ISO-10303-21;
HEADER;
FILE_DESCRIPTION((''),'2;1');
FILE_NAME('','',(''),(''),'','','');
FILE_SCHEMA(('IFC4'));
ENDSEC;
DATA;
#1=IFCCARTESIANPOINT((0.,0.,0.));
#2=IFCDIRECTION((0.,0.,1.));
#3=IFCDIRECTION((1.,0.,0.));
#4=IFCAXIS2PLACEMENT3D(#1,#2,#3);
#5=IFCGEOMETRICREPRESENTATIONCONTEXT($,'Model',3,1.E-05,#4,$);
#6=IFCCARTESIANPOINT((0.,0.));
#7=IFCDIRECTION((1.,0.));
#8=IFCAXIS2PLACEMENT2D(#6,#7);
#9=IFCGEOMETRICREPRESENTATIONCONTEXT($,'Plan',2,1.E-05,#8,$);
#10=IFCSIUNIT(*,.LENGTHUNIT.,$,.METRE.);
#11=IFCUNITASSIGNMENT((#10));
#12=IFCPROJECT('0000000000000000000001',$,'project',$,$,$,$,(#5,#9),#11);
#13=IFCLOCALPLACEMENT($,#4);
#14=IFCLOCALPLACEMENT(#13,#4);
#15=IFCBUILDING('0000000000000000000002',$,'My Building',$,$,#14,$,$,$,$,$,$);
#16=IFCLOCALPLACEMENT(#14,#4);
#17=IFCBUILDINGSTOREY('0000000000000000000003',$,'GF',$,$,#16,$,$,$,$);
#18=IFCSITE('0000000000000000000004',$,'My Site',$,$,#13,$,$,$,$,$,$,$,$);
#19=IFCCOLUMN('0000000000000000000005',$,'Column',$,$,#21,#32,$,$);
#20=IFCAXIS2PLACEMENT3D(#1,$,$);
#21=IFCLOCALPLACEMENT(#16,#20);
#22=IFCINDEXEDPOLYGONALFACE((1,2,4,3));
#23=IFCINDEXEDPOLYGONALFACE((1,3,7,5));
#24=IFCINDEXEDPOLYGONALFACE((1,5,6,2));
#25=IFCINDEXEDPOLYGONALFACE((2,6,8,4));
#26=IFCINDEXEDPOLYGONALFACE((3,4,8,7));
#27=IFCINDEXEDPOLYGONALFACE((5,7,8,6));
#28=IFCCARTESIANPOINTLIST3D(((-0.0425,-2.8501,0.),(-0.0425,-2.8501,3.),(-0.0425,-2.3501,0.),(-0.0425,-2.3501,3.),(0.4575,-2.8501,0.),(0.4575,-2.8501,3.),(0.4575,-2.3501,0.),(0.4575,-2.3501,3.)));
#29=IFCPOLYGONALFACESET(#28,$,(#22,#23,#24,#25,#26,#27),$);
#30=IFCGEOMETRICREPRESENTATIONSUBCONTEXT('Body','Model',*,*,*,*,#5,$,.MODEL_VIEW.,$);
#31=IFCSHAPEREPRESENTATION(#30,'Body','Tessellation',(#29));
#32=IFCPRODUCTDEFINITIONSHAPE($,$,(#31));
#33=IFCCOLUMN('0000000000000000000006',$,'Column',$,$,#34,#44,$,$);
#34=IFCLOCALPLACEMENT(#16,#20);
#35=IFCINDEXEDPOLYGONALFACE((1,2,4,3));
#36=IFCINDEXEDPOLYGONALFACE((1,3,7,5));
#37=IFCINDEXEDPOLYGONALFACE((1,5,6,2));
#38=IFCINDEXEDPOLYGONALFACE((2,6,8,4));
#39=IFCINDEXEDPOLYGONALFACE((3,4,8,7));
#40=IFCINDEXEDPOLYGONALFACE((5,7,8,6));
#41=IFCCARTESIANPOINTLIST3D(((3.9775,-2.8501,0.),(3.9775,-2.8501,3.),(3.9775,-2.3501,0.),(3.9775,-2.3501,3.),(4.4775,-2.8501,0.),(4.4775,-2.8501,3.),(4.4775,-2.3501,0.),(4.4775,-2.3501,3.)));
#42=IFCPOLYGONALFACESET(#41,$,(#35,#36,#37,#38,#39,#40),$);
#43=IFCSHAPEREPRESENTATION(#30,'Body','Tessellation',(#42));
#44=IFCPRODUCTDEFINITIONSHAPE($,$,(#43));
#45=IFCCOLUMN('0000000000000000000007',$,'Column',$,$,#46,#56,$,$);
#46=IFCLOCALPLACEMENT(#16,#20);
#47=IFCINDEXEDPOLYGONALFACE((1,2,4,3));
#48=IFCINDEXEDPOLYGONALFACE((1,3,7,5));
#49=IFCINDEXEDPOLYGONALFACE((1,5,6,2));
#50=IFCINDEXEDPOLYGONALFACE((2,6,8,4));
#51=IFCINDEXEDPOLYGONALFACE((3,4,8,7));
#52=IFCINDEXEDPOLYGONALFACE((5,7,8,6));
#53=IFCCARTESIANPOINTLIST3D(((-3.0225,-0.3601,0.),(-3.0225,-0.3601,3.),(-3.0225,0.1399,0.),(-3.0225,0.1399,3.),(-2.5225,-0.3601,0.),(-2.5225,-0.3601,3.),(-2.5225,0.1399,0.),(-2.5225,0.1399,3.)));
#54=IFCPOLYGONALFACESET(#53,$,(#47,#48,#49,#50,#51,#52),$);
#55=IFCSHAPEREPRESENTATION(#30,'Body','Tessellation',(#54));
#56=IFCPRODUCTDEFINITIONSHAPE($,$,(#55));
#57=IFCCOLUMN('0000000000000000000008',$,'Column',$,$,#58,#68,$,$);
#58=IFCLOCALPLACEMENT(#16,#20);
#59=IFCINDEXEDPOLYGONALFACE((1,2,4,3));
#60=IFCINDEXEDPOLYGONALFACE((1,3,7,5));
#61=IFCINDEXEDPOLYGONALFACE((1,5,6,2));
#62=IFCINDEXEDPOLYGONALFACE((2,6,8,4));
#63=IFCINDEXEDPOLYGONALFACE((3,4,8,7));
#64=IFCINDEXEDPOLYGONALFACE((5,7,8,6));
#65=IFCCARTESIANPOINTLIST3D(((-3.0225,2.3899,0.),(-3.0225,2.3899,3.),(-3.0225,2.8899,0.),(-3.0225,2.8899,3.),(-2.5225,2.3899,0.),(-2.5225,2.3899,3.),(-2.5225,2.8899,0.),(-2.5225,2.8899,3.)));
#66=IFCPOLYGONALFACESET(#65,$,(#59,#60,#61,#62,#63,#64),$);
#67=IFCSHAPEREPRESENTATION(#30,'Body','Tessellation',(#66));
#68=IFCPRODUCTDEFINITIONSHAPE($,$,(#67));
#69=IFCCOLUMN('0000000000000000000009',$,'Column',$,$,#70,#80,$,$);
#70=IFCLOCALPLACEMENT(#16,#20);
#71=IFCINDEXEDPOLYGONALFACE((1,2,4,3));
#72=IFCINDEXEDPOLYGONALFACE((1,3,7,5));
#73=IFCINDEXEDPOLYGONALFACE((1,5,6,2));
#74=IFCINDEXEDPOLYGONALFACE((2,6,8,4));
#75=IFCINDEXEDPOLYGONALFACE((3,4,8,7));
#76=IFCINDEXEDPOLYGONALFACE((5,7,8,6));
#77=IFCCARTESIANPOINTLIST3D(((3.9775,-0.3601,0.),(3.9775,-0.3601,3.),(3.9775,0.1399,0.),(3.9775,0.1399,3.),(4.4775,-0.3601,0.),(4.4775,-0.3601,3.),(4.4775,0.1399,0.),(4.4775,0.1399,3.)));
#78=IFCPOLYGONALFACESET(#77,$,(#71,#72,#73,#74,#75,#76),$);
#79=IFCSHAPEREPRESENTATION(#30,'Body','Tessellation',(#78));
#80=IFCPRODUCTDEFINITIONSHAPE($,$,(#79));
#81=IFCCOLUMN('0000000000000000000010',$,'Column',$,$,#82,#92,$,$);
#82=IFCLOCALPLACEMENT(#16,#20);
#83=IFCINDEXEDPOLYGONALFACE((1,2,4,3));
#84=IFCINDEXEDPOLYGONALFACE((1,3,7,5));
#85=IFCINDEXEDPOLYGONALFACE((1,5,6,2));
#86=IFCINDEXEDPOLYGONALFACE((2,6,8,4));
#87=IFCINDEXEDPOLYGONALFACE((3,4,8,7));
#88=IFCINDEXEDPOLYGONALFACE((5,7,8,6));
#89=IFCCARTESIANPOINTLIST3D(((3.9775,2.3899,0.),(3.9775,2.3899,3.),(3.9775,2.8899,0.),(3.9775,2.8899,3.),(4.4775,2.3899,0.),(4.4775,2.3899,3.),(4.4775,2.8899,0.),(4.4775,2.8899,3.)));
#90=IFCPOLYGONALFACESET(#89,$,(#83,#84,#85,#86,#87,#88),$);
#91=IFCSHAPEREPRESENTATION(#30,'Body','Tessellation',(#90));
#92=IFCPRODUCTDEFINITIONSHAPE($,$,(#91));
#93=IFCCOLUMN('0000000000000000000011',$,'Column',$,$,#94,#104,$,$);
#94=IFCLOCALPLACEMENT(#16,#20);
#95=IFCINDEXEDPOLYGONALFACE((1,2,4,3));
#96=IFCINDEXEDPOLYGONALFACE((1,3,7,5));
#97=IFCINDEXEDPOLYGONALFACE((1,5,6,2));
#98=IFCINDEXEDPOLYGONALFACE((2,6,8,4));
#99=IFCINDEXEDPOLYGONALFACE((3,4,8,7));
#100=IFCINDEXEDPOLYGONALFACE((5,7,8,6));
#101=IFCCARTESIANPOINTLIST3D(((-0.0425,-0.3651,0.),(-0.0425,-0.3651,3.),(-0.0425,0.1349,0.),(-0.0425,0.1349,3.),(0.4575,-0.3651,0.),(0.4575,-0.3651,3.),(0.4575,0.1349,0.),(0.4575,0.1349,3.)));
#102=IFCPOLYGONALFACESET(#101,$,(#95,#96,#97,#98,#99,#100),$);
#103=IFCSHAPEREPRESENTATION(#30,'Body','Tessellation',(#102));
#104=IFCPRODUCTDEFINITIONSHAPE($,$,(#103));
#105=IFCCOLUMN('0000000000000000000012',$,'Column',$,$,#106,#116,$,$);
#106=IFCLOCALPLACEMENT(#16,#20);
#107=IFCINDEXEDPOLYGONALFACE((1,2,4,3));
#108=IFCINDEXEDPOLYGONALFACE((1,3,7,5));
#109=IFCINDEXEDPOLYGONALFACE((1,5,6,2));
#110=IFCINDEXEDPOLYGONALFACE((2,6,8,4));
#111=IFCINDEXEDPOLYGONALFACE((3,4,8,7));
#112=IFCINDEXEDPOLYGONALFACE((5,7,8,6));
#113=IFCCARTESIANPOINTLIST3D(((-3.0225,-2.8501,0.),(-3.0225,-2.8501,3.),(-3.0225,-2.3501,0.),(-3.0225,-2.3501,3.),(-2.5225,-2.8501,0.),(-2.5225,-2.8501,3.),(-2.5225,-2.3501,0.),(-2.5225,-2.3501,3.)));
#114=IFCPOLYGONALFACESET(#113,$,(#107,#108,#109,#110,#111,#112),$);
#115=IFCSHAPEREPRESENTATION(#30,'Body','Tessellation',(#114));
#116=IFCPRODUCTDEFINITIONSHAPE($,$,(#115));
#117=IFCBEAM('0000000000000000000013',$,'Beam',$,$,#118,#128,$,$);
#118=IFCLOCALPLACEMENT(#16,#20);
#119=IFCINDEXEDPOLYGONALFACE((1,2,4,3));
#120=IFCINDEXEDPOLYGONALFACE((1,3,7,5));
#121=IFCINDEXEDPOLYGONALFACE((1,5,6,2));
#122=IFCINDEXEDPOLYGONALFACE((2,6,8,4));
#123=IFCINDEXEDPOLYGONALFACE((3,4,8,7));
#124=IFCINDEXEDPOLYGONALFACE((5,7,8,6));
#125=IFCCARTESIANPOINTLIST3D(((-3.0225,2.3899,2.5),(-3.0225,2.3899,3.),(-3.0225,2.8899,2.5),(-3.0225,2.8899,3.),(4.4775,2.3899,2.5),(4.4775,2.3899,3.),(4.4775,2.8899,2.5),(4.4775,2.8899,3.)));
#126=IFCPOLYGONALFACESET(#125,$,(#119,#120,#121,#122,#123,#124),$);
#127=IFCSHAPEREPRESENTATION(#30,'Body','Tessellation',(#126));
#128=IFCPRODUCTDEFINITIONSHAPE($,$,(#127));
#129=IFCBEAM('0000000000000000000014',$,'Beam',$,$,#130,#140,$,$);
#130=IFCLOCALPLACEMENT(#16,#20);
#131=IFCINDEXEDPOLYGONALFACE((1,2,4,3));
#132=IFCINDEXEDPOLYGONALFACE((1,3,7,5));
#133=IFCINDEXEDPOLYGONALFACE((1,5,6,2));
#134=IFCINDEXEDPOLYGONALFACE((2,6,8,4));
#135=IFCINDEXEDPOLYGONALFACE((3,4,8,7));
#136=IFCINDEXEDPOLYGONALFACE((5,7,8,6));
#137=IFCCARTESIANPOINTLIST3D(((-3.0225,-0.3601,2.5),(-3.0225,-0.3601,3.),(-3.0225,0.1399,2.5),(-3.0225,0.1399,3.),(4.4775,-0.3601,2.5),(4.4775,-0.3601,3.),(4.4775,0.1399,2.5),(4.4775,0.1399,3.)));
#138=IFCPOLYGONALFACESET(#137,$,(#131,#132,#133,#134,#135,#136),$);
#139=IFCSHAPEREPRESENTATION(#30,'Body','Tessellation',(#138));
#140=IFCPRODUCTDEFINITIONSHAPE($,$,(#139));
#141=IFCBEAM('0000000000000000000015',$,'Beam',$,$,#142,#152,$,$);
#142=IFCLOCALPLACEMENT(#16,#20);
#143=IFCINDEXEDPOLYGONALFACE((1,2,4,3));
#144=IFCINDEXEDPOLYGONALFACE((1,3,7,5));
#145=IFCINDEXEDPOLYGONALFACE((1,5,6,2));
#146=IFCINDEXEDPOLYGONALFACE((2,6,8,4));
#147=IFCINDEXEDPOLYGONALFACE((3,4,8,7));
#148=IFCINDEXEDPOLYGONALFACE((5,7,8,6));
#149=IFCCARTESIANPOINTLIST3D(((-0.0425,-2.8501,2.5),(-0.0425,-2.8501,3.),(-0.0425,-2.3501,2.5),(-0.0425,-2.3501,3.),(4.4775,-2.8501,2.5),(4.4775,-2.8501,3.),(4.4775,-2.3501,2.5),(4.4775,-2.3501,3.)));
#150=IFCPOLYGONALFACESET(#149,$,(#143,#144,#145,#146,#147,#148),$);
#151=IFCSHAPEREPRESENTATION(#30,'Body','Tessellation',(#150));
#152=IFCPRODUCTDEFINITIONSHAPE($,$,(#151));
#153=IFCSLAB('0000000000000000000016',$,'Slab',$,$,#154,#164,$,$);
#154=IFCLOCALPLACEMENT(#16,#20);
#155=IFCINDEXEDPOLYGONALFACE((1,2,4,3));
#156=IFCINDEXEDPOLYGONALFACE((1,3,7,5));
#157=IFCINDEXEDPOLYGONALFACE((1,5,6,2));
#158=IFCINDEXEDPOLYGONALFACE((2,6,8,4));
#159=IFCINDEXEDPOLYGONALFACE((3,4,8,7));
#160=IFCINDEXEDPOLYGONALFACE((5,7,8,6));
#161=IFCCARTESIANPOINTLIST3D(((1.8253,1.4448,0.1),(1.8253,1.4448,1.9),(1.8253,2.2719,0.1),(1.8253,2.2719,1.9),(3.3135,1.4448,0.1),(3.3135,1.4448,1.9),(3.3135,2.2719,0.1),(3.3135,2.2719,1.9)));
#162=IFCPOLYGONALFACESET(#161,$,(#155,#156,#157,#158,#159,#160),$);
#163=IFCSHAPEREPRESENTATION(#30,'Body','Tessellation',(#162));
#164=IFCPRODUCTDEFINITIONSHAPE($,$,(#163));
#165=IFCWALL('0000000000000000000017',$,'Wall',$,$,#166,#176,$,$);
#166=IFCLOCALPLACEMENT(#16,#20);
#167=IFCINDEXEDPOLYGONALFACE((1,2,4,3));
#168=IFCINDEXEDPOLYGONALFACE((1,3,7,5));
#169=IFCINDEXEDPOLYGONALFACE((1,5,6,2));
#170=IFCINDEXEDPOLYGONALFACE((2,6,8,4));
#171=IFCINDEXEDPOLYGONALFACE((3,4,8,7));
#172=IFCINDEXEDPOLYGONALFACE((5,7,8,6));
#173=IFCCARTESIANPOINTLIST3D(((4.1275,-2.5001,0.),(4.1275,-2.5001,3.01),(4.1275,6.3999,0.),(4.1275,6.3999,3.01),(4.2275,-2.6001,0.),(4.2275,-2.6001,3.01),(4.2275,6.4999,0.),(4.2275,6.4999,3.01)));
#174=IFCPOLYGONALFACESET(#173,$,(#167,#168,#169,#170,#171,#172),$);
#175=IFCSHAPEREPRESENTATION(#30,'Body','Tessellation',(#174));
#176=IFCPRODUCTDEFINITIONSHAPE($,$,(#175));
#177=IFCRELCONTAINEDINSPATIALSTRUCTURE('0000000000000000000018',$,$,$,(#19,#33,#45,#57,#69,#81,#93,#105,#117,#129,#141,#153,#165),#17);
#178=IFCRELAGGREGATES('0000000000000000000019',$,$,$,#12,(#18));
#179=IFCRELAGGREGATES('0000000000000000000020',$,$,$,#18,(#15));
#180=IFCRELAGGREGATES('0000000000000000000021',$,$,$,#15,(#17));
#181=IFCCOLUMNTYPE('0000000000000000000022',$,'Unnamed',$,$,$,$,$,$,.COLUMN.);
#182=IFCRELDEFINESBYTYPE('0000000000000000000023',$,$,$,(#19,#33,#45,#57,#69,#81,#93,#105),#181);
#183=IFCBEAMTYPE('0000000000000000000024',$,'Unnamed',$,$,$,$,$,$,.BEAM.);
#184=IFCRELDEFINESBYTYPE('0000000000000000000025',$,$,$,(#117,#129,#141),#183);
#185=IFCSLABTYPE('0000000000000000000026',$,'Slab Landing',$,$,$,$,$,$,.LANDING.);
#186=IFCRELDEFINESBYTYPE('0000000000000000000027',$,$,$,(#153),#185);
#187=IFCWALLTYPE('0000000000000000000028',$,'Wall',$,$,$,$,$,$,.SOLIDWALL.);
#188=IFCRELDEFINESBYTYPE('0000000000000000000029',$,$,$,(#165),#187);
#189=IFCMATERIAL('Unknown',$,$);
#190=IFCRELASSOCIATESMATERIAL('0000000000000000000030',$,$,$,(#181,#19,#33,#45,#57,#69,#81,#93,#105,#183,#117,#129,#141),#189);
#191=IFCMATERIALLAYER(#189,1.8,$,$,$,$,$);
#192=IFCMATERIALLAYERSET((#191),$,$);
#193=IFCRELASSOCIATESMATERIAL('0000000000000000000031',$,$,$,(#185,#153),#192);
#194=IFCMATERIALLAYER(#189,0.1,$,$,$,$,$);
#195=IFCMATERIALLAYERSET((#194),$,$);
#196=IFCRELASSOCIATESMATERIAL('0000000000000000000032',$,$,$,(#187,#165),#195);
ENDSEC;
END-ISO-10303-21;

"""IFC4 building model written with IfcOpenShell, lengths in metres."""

from ifc_helpers import new_model, si_unit, frame, origin_with_axes, origin_2d_with_axis, place, context, subcontext, project, spatial, line, indexed_curve, rectangle, outline, extrude, material, layer, layer_set, layer_usage, material_profile, profile_set, profile_usage, type_object, element, save


model = new_model("IFC4")

# Units and contexts
model_context = context("Model", 3, precision=1e-05, world=origin_with_axes())
plan_context = context("Plan", 2, precision=1e-05, world=origin_2d_with_axis())
body_context_1 = subcontext(model_context, "Body", "Model", "MODEL_VIEW")
ifc_project = project(units=[si_unit("LENGTHUNIT", "METRE")], contexts=[model_context, plan_context])

# Site, building, storey
site_placement = place(None, origin_with_axes())
site = spatial("IfcSite", under=ifc_project, at=site_placement, Name="My Site")
building_placement = place(site_placement, origin_with_axes())
building = spatial("IfcBuilding", under=site, at=building_placement, Name="My Building")
storey_placement = place(building_placement, origin_with_axes())
storey = spatial("IfcBuildingStorey", under=building, at=storey_placement, Name="GF")

# Columns
ifc_material = material(Name="Unknown")
ifc_material_profile_1 = material_profile(ifc_material, rectangle(XDim=0.5, YDim=0.5))
ifc_profile_set_1 = profile_set([ifc_material_profile_1])
ifc_profile_usage_1 = profile_usage(ifc_profile_set_1, cardinal=5)
column_type = type_object("IfcColumnType", Name="Unnamed", PredefinedType="COLUMN", material=ifc_profile_set_1)
column_1_placement = place(storey_placement, frame((0.2075, -2.6001, 0.0), z_axis=(0.0, 0.0, 1.0), x_axis=(1.0, 0.0, 0.0)))
element("IfcColumn", 1, at=column_1_placement, inside=storey, type_object=column_type, material=ifc_profile_usage_1, Name="Column", context=body_context_1, shape_type="SweptSolid", body=[
    extrude(rectangle(XDim=0.5, YDim=0.5), origin_with_axes(), (0.0, 0.0, 1.0), 3.0),
])
ifc_profile_usage_2 = profile_usage(ifc_profile_set_1, cardinal=5)
column_2_placement = place(storey_placement, frame((4.2275, -2.6001, 0.0), z_axis=(0.0, 0.0, 1.0), x_axis=(1.0, 0.0, 0.0)))
element("IfcColumn", 2, at=column_2_placement, inside=storey, type_object=column_type, material=ifc_profile_usage_2, Name="Column", context=body_context_1, shape_type="SweptSolid", body=[
    extrude(rectangle(XDim=0.5, YDim=0.5), origin_with_axes(), (0.0, 0.0, 1.0), 3.0),
])
ifc_profile_usage_3 = profile_usage(ifc_profile_set_1, cardinal=5)
column_3_placement = place(storey_placement, frame((-2.7725, -0.1101, 0.0), z_axis=(0.0, 0.0, 1.0), x_axis=(1.0, 0.0, 0.0)))
element("IfcColumn", 3, at=column_3_placement, inside=storey, type_object=column_type, material=ifc_profile_usage_3, Name="Column", context=body_context_1, shape_type="SweptSolid", body=[
    extrude(rectangle(XDim=0.5, YDim=0.5), origin_with_axes(), (0.0, 0.0, 1.0), 3.0),
])
ifc_profile_usage_4 = profile_usage(ifc_profile_set_1, cardinal=5)
column_4_placement = place(storey_placement, frame((-2.7725, 2.6399, 0.0), z_axis=(0.0, 0.0, 1.0), x_axis=(1.0, 0.0, 0.0)))
element("IfcColumn", 4, at=column_4_placement, inside=storey, type_object=column_type, material=ifc_profile_usage_4, Name="Column", context=body_context_1, shape_type="SweptSolid", body=[
    extrude(rectangle(XDim=0.5, YDim=0.5), origin_with_axes(), (0.0, 0.0, 1.0), 3.0),
])
ifc_profile_usage_5 = profile_usage(ifc_profile_set_1, cardinal=5)
column_5_placement = place(storey_placement, frame((4.2275, -0.1101, 0.0), z_axis=(0.0, 0.0, 1.0), x_axis=(1.0, 0.0, 0.0)))
element("IfcColumn", 5, at=column_5_placement, inside=storey, type_object=column_type, material=ifc_profile_usage_5, Name="Column", context=body_context_1, shape_type="SweptSolid", body=[
    extrude(rectangle(XDim=0.5, YDim=0.5), origin_with_axes(), (0.0, 0.0, 1.0), 3.0),
])
ifc_profile_usage_6 = profile_usage(ifc_profile_set_1, cardinal=5)
column_6_placement = place(storey_placement, frame((4.2275, 2.6399, 0.0), z_axis=(0.0, 0.0, 1.0), x_axis=(1.0, 0.0, 0.0)))
element("IfcColumn", 6, at=column_6_placement, inside=storey, type_object=column_type, material=ifc_profile_usage_6, Name="Column", context=body_context_1, shape_type="SweptSolid", body=[
    extrude(rectangle(XDim=0.5, YDim=0.5), origin_with_axes(), (0.0, 0.0, 1.0), 3.0),
])
ifc_profile_usage_7 = profile_usage(ifc_profile_set_1, cardinal=5)
column_7_placement = place(storey_placement, frame((0.2075, -0.1151, 0.0), z_axis=(0.0, 0.0, 1.0), x_axis=(1.0, 0.0, 0.0)))
element("IfcColumn", 7, at=column_7_placement, inside=storey, type_object=column_type, material=ifc_profile_usage_7, Name="Column", context=body_context_1, shape_type="SweptSolid", body=[
    extrude(rectangle(XDim=0.5, YDim=0.5), origin_with_axes(), (0.0, 0.0, 1.0), 3.0),
])
ifc_profile_usage_8 = profile_usage(ifc_profile_set_1, cardinal=5)
column_8_placement = place(storey_placement, frame((-2.7725, -2.6001, 0.0), z_axis=(0.0, 0.0, 1.0), x_axis=(1.0, 0.0, 0.0)))
element("IfcColumn", 8, at=column_8_placement, inside=storey, type_object=column_type, material=ifc_profile_usage_8, Name="Column", context=body_context_1, shape_type="SweptSolid", body=[
    extrude(rectangle(XDim=0.5, YDim=0.5), origin_with_axes(), (0.0, 0.0, 1.0), 3.0),
])

# Beams
ifc_material_profile_2 = material_profile(ifc_material, rectangle(XDim=0.5, YDim=0.5))
ifc_profile_set_2 = profile_set([ifc_material_profile_2])
ifc_profile_usage_9 = profile_usage(ifc_profile_set_2, cardinal=7)
beam_type = type_object("IfcBeamType", Name="Unnamed", PredefinedType="BEAM", material=ifc_profile_set_2)
beam_1_placement = place(storey_placement, frame((4.4775, 2.3899, 3.0), z_axis=(-1.0, 0.0, 0.0), x_axis=(0.0, -1.0, 0.0)))
element("IfcBeam", 9, at=beam_1_placement, inside=storey, type_object=beam_type, material=ifc_profile_usage_9, Name="Beam", context=body_context_1, shape_type="SweptSolid", body=[
    extrude(rectangle(XDim=0.5, YDim=0.5), frame((-0.25, -0.25, 0.0), z_axis=(0.0, 0.0, 1.0), x_axis=(1.0, 0.0, 0.0)), (0.0, 0.0, 1.0), 7.5),
])
ifc_profile_usage_10 = profile_usage(ifc_profile_set_2, cardinal=7)
beam_2_placement = place(storey_placement, frame((4.4775, -0.3601, 3.0), z_axis=(-1.0, 0.0, 0.0), x_axis=(0.0, -1.0, 0.0)))
element("IfcBeam", 10, at=beam_2_placement, inside=storey, type_object=beam_type, material=ifc_profile_usage_10, Name="Beam", context=body_context_1, shape_type="SweptSolid", body=[
    extrude(rectangle(XDim=0.5, YDim=0.5), frame((-0.25, -0.25, 0.0), z_axis=(0.0, 0.0, 1.0), x_axis=(1.0, 0.0, 0.0)), (0.0, 0.0, 1.0), 7.5),
])
ifc_profile_usage_11 = profile_usage(ifc_profile_set_2, cardinal=7)
beam_3_placement = place(storey_placement, frame((4.4775, -2.8501, 3.0), z_axis=(-1.0, 0.0, 0.0), x_axis=(0.0, -1.0, 0.0)))
element("IfcBeam", 11, at=beam_3_placement, inside=storey, type_object=beam_type, material=ifc_profile_usage_11, Name="Beam", context=body_context_1, shape_type="SweptSolid", body=[
    extrude(rectangle(XDim=0.5, YDim=0.5), frame((-0.25, -0.25, 0.0), z_axis=(0.0, 0.0, 1.0), x_axis=(1.0, 0.0, 0.0)), (0.0, 0.0, 1.0), 4.52),
])

# Slab
ifc_layer_1 = layer(ifc_material, 1.8)
ifc_layer_set_1 = layer_set([ifc_layer_1])
slab_type = type_object("IfcSlabType", Name="Slab Landing", PredefinedType="LANDING", material=ifc_layer_set_1)
ifc_layer_usage_1 = layer_usage(ifc_layer_set_1, "AXIS3", "POSITIVE", -1.8)
slab_1_placement = place(storey_placement, frame((3.3135, 2.2719, 1.9), z_axis=(0.0, 0.0, 1.0), x_axis=(1.0, 0.0, 0.0)))
element("IfcSlab", 12, at=slab_1_placement, inside=storey, type_object=slab_type, material=ifc_layer_usage_1, Name="Slab", context=body_context_1, shape_type="SweptSolid", body=[
    extrude(outline(indexed_curve([(0.0, 0.0), (0.0, -0.827), (-1.4882, -0.827), (-1.4882, 0.0), (0.0, 0.0)])), frame((0.0, 0.0, -1.8), z_axis=(0.0, 0.0, 1.0), x_axis=(1.0, 0.0, 0.0)), (0.0, 0.0, 1.0), 1.8),
])

# Shared definitions
ifc_layer_2 = layer(ifc_material, 0.1)
ifc_layer_set_2 = layer_set([ifc_layer_2])
wall_type = type_object("IfcWallType", Name="Wall", PredefinedType="SOLIDWALL", material=ifc_layer_set_2)

# Wall
ifc_layer_usage_2 = layer_usage(ifc_layer_set_2, "AXIS2", "POSITIVE", 0.0)
wall_1_placement = place(storey_placement, frame((4.2275, -2.6001, 0.0), z_axis=(0.0, 0.0, 1.0), x_axis=(0.0, 1.0, 0.0)))
element("IfcWall", 13, at=wall_1_placement, inside=storey, type_object=wall_type, material=ifc_layer_usage_2, Name="Wall", context=body_context_1, shape_type="SweptSolid", body=[
    extrude(outline(indexed_curve([(0.0, 0.0), (0.1, 0.1), (9.0, 0.1), (9.1, 0.0)], segments=[line(1, 2, 3, 4, 1)])), origin_with_axes(), (0.0, 0.0, 1.0), 3.01),
])

save(model, "model.ifc")
